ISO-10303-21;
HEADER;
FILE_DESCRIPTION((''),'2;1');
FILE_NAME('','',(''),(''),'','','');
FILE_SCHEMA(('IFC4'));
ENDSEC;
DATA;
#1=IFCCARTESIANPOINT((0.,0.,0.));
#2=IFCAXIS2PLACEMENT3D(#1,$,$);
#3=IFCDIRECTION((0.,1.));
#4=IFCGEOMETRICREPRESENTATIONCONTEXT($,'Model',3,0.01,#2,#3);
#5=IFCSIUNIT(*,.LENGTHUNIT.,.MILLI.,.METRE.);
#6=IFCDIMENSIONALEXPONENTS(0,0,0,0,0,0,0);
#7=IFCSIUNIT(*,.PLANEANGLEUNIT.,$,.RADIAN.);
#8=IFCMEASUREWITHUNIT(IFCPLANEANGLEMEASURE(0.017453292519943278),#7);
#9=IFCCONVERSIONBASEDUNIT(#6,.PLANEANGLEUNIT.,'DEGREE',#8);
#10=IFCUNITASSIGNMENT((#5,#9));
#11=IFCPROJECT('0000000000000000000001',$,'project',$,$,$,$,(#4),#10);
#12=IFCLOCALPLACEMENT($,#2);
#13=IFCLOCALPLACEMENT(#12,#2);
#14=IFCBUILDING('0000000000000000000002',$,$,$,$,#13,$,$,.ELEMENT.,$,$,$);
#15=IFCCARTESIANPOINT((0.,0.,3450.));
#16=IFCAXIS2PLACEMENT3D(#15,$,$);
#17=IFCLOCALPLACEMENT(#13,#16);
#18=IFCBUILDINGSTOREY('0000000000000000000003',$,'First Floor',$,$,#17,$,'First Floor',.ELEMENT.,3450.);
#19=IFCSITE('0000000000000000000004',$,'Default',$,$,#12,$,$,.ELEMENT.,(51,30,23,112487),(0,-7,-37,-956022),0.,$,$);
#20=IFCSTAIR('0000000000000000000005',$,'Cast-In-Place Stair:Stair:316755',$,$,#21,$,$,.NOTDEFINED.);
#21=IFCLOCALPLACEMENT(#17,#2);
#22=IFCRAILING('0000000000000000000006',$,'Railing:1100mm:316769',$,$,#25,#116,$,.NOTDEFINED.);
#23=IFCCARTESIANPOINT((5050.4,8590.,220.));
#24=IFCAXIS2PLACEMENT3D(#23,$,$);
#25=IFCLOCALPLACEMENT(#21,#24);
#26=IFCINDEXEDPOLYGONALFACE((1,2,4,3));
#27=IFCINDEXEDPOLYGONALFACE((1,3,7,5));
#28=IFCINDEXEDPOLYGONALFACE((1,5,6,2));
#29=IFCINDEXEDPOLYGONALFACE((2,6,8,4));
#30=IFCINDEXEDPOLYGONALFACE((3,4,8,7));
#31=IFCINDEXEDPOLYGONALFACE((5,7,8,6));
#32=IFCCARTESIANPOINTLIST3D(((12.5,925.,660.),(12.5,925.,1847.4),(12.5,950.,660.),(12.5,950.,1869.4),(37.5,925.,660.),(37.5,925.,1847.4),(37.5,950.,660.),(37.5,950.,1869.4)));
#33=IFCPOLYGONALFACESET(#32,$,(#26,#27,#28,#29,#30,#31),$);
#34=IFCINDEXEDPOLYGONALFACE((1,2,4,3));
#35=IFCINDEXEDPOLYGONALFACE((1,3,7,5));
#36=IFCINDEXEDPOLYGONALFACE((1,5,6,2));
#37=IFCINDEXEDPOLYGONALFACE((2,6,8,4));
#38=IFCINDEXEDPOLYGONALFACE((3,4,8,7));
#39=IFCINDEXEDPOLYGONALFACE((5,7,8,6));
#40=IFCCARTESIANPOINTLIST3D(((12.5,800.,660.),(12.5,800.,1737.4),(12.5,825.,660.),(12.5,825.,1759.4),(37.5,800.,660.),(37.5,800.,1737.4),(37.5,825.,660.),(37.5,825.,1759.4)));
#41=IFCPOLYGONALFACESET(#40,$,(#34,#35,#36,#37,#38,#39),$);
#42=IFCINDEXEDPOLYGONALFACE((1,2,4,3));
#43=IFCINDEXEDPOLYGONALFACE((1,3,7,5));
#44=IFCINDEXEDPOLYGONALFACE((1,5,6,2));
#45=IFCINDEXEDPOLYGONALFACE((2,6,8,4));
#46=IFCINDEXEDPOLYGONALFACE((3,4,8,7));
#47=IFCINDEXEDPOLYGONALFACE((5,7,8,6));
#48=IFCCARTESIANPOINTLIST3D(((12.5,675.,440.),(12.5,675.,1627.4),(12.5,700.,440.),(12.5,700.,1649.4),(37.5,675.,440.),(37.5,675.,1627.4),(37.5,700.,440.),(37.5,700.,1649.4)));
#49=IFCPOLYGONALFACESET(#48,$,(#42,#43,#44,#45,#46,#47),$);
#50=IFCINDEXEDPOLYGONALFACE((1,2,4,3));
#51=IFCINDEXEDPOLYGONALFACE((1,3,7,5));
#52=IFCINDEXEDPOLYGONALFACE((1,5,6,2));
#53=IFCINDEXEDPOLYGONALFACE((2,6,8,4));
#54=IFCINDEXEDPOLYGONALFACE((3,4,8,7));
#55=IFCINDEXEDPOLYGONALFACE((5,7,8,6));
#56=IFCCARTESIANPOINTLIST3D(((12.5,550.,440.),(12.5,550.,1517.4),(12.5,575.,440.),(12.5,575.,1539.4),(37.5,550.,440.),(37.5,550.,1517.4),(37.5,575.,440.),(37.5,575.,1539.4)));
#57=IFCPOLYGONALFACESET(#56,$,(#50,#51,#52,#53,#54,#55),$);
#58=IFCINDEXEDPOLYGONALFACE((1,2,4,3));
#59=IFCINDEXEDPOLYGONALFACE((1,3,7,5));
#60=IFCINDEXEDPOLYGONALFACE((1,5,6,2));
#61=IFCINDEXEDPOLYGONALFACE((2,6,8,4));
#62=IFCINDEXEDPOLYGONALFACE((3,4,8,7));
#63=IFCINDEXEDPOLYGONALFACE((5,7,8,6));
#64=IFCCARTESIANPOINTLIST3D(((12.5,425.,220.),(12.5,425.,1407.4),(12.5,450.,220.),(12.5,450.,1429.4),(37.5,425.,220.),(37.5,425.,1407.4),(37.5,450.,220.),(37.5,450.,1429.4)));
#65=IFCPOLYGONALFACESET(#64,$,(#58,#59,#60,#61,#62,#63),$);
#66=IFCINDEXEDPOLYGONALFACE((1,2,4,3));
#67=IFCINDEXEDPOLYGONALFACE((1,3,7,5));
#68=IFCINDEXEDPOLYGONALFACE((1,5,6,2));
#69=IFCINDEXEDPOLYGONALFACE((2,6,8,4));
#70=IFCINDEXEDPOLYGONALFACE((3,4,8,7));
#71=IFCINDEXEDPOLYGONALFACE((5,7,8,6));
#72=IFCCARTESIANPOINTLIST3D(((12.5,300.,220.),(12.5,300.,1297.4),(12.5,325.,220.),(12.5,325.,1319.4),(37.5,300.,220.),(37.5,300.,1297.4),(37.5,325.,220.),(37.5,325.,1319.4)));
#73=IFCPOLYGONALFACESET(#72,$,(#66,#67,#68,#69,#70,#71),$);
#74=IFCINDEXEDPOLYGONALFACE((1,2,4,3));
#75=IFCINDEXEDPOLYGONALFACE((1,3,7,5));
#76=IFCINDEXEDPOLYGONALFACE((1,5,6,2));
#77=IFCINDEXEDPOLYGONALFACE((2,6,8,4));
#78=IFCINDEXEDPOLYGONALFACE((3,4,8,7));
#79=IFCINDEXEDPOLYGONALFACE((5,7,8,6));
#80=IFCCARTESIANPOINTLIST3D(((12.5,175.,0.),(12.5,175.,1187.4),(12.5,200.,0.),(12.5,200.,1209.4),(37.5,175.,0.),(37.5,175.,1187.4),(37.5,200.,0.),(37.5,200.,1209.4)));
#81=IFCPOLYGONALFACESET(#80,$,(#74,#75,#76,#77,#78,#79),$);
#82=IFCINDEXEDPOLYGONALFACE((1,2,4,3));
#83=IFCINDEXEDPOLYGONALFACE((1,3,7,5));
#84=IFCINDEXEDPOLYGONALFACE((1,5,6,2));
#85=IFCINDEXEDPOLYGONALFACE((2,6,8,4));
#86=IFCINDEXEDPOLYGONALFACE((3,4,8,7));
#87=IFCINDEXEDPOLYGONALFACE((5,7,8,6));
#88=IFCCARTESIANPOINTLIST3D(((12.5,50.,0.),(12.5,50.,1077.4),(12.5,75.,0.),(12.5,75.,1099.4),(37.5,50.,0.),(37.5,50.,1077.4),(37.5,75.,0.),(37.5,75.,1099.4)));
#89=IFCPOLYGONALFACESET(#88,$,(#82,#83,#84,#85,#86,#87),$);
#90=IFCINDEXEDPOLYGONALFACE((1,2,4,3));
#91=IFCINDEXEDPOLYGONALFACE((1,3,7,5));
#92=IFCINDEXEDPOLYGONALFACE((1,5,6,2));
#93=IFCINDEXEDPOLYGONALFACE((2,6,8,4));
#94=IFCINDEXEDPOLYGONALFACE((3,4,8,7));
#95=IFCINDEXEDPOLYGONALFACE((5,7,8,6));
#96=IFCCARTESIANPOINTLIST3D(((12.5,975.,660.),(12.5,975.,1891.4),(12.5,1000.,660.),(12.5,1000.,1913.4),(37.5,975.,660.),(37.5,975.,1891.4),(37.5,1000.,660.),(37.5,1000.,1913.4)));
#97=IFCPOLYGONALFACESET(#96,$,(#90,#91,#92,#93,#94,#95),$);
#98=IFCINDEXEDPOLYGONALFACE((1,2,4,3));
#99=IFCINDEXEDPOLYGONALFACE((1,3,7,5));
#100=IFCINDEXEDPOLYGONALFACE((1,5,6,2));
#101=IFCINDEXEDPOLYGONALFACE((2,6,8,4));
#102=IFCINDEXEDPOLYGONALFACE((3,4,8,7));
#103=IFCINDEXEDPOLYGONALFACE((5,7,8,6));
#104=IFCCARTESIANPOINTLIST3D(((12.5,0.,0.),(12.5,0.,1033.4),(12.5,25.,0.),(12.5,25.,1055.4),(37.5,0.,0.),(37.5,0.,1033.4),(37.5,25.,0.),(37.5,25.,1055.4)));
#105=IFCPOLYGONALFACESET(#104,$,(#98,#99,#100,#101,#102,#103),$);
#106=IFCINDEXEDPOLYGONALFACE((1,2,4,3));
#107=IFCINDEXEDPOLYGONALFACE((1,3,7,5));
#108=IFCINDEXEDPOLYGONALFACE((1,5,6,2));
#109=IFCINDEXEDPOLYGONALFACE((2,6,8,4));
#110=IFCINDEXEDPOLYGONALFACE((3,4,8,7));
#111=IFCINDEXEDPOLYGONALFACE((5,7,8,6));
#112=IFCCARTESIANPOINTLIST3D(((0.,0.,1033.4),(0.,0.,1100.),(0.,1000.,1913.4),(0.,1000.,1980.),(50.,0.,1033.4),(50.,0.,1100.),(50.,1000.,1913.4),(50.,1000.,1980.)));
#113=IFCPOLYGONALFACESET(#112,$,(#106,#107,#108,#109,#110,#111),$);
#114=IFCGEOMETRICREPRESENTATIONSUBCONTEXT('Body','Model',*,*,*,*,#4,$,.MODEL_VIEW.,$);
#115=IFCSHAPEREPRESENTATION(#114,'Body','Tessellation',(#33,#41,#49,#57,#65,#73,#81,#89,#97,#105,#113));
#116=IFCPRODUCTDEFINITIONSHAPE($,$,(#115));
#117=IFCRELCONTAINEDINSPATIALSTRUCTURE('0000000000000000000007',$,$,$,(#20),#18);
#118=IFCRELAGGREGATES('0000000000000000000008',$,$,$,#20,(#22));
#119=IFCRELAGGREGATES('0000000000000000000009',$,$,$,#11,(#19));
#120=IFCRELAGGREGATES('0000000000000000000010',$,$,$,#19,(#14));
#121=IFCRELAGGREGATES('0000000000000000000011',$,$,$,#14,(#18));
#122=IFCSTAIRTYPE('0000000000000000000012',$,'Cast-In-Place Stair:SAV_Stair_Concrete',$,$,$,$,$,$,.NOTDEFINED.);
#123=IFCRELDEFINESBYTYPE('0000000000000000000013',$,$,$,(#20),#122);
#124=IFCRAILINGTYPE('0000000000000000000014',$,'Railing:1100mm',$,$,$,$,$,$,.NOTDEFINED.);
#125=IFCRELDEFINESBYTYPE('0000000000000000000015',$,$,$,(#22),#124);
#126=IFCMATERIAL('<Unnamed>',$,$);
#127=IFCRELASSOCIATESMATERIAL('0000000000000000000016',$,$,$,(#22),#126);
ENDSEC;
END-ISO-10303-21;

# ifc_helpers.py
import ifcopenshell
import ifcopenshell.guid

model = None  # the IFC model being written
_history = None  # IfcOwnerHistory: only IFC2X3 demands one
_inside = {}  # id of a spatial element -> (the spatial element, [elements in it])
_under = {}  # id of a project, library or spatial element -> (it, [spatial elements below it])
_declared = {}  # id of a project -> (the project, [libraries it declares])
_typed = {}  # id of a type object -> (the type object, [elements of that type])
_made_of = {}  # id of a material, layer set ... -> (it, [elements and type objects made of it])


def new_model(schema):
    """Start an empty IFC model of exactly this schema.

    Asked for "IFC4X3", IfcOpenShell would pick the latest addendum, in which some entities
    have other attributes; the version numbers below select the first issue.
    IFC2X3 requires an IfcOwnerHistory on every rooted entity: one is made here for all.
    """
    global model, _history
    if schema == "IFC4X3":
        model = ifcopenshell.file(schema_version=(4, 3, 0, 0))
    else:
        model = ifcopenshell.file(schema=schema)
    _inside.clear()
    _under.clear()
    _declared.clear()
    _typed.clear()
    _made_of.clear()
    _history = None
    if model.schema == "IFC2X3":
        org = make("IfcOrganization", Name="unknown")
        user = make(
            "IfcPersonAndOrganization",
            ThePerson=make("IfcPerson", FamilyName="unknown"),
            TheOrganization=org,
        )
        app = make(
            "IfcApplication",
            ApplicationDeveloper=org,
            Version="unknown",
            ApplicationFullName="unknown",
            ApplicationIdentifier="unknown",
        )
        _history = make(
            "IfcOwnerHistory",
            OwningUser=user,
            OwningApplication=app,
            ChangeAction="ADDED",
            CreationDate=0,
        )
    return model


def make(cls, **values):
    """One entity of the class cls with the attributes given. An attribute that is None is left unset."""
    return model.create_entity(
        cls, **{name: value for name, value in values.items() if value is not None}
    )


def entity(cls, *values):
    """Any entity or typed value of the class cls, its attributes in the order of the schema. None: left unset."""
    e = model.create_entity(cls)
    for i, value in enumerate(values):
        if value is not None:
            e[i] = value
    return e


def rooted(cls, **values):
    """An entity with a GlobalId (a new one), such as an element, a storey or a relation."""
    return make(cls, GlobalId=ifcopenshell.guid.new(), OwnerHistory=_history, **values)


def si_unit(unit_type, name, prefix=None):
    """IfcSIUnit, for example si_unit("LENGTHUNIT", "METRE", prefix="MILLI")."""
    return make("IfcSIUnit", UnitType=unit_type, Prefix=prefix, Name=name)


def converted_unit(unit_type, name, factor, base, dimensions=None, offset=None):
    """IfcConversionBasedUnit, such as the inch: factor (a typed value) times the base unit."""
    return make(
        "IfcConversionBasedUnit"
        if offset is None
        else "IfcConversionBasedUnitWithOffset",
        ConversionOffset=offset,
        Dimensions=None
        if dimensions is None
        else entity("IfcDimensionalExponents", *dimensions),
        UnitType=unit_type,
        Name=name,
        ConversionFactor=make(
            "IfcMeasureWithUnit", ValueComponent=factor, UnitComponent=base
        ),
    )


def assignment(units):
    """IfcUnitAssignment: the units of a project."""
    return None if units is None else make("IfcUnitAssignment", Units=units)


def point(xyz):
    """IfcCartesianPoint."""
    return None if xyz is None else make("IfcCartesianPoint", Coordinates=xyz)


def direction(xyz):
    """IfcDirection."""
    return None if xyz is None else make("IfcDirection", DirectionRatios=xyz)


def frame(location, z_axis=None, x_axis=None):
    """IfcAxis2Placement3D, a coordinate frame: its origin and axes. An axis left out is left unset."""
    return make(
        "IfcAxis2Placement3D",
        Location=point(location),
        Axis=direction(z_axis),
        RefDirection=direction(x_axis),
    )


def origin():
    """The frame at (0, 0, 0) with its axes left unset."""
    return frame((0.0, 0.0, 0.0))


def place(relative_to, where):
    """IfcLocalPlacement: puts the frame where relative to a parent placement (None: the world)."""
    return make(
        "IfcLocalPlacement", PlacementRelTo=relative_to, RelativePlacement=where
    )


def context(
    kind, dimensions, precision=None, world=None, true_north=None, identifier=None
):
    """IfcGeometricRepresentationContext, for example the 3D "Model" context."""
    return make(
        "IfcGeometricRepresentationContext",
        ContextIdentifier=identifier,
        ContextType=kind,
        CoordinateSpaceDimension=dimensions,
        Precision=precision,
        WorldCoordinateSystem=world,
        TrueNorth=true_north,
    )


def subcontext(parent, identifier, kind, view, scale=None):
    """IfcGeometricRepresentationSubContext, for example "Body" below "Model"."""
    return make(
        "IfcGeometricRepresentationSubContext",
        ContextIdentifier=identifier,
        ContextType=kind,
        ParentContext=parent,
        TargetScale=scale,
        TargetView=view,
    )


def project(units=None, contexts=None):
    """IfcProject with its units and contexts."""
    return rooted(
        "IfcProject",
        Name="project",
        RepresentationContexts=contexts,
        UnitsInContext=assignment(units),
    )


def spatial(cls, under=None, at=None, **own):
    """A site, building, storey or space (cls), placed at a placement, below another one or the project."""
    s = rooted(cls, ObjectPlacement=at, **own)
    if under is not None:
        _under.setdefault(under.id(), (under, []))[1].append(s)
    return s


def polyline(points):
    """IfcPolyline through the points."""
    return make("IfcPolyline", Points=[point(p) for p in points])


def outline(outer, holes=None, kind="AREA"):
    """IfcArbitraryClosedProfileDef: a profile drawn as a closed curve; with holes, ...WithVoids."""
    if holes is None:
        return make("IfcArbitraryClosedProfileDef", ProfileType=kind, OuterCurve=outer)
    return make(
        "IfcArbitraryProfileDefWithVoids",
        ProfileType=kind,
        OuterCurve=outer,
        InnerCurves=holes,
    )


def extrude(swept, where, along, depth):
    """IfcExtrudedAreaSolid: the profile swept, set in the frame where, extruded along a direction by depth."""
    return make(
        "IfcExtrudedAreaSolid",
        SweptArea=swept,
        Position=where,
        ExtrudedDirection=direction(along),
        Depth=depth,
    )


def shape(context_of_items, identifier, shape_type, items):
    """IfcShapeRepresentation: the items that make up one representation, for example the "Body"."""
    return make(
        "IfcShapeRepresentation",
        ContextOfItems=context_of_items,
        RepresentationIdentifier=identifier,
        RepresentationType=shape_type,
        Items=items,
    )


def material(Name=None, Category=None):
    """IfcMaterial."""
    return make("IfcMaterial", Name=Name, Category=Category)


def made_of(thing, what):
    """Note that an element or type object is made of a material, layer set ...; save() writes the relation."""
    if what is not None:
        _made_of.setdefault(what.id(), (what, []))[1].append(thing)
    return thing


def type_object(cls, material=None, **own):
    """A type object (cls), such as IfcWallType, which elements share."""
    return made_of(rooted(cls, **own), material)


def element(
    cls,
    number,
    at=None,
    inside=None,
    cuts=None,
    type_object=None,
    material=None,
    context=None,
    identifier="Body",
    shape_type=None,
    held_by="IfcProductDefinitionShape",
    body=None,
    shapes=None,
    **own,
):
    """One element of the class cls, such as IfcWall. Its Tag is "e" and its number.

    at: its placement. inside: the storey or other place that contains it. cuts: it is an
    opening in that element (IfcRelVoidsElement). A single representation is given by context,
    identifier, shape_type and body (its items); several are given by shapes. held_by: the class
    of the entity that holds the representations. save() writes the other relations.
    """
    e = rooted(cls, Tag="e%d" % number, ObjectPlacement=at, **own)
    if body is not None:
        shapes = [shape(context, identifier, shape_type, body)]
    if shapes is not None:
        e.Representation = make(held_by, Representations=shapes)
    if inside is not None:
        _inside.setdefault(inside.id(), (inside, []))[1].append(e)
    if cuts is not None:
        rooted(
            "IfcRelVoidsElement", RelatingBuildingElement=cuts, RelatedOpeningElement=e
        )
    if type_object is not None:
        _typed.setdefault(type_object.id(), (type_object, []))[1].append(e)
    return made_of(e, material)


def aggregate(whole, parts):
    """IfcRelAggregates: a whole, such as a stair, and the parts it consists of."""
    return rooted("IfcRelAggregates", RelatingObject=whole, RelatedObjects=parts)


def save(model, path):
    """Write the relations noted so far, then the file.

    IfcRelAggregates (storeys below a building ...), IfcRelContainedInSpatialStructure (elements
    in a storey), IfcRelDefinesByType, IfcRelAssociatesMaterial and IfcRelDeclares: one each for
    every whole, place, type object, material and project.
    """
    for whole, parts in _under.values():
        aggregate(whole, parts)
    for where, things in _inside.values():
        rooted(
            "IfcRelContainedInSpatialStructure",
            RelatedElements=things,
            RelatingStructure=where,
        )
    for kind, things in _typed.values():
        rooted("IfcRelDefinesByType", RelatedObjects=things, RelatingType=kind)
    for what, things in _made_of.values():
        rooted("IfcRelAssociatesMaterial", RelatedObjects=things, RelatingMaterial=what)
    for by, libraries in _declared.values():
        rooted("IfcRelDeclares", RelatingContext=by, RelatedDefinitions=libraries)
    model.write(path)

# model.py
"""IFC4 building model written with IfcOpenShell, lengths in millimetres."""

from ifc_helpers import new_model, entity, si_unit, converted_unit, direction, frame, origin, place, context, subcontext, project, spatial, polyline, outline, extrude, material, type_object, element, aggregate, save


model = new_model("IFC4")

# Units and contexts
model_context = context("Model", 3, precision=0.01, world=origin(), true_north=direction((0.0, 1.0)))
body_context = subcontext(model_context, "Body", "Model", "MODEL_VIEW")
ifc_project = project(units=[si_unit("LENGTHUNIT", "METRE", prefix="MILLI"), converted_unit("PLANEANGLEUNIT", "DEGREE", entity("IfcPlaneAngleMeasure", 0.017453292519943278), si_unit("PLANEANGLEUNIT", "RADIAN"), dimensions=[0, 0, 0, 0, 0, 0, 0])], contexts=[model_context])

# Site, building, storey
site_placement = place(None, origin())
site = spatial("IfcSite", under=ifc_project, at=site_placement, Name="Default", CompositionType="ELEMENT", RefLatitude=(51, 30, 23, 112487), RefLongitude=(0, -7, -37, -956022), RefElevation=0.0)
building_placement = place(site_placement, origin())
building = spatial("IfcBuilding", under=site, at=building_placement, CompositionType="ELEMENT")
storey_placement = place(building_placement, frame((0.0, 0.0, 3450.0)))
storey = spatial("IfcBuildingStorey", under=building, at=storey_placement, Name="First Floor", LongName="First Floor", CompositionType="ELEMENT", Elevation=3450.0)

# Shared definitions
ifc_material_1 = material(Name="<Unnamed>")

# Stair, railing
stair_type = type_object("IfcStairType", Name="Cast-In-Place Stair:SAV_Stair_Concrete", PredefinedType="NOTDEFINED")
stair_placement = place(storey_placement, origin())
stair = element("IfcStair", 1, at=stair_placement, inside=storey, type_object=stair_type, Name="Cast-In-Place Stair:Stair:316755", PredefinedType="NOTDEFINED")
railing_type_1 = type_object("IfcRailingType", Name="Railing:1100mm", PredefinedType="NOTDEFINED")
railing_1_placement = place(stair_placement, frame((5050.4, 8590.0, 220.0)))
railing_1 = element("IfcRailing", 2, at=railing_1_placement, type_object=railing_type_1, material=ifc_material_1, Name="Railing:1100mm:316769", PredefinedType="NOTDEFINED", context=body_context, shape_type="SweptSolid", body=[
    extrude(outline(polyline([(-588.2, -12.5), (599.2, -12.5), (599.2, 12.5), (-610.2, 12.5), (-588.2, -12.5)])), frame((12.5, 937.5, 1259.2), z_axis=(1.0, 0.0, 0.0), x_axis=(0.0, 0.0, -1.0)), (0.0, 0.0, 1.0), 25.0),
    extrude(outline(polyline([(-533.2, -12.5), (544.2, -12.5), (544.2, 12.5), (-555.2, 12.5), (-533.2, -12.5)])), frame((12.5, 812.5, 1204.2), z_axis=(1.0, 0.0, 0.0), x_axis=(0.0, 0.0, -1.0)), (0.0, 0.0, 1.0), 25.0),
    extrude(outline(polyline([(-588.2, -12.5), (599.2, -12.5), (599.2, 12.5), (-610.2, 12.5), (-588.2, -12.5)])), frame((12.5, 687.5, 1039.2), z_axis=(1.0, 0.0, 0.0), x_axis=(0.0, 0.0, -1.0)), (0.0, 0.0, 1.0), 25.0),
    extrude(outline(polyline([(-533.2, -12.5), (544.2, -12.5), (544.2, 12.5), (-555.2, 12.5), (-533.2, -12.5)])), frame((12.5, 562.5, 984.2), z_axis=(1.0, 0.0, 0.0), x_axis=(0.0, 0.0, -1.0)), (0.0, 0.0, 1.0), 25.0),
    extrude(outline(polyline([(-588.2, -12.5), (599.2, -12.5), (599.2, 12.5), (-610.2, 12.5), (-588.2, -12.5)])), frame((12.5, 437.5, 819.2), z_axis=(1.0, 0.0, 0.0), x_axis=(0.0, 0.0, -1.0)), (0.0, 0.0, 1.0), 25.0),
    extrude(outline(polyline([(-533.2, -12.5), (544.2, -12.5), (544.2, 12.5), (-555.2, 12.5), (-533.2, -12.5)])), frame((12.5, 312.5, 764.2), z_axis=(1.0, 0.0, 0.0), x_axis=(0.0, 0.0, -1.0)), (0.0, 0.0, 1.0), 25.0),
    extrude(outline(polyline([(-588.2, -12.5), (599.2, -12.5), (599.2, 12.5), (-610.2, 12.5), (-588.2, -12.5)])), frame((12.5, 187.5, 599.2), z_axis=(1.0, 0.0, 0.0), x_axis=(0.0, 0.0, -1.0)), (0.0, 0.0, 1.0), 25.0),
    extrude(outline(polyline([(-533.2, -12.5), (544.2, -12.5), (544.2, 12.5), (-555.2, 12.5), (-533.2, -12.5)])), frame((12.5, 62.5, 544.2), z_axis=(1.0, 0.0, 0.0), x_axis=(0.0, 0.0, -1.0)), (0.0, 0.0, 1.0), 25.0),
    extrude(outline(polyline([(-610.2, -12.5), (621.2, -12.5), (621.2, 12.5), (-632.2, 12.5), (-610.2, -12.5)])), frame((12.5, 987.5, 1281.2), z_axis=(1.0, 0.0, 0.0), x_axis=(0.0, 0.0, -1.0)), (0.0, 0.0, 1.0), 25.0),
    extrude(outline(polyline([(-511.2, -12.5), (522.2, -12.5), (522.2, 12.5), (-533.2, 12.5), (-511.2, -12.5)])), frame((12.5, 12.5, 522.2), z_axis=(1.0, 0.0, 0.0), x_axis=(0.0, 0.0, -1.0)), (0.0, 0.0, 1.0), 25.0),
    extrude(outline(polyline([(-688.0, -25.0), (644.0, -25.0), (688.0, 25.0), (-644.0, 25.0), (-688.0, -25.0)])), frame((0.0, 500.0, 1506.7), z_axis=(1.0, 0.0, 0.0), x_axis=(0.0, 0.750714, 0.660628)), (0.0, 0.0, 1.0), 50.0),
])
aggregate(stair, [railing_1])

save(model, "model.ifc")
